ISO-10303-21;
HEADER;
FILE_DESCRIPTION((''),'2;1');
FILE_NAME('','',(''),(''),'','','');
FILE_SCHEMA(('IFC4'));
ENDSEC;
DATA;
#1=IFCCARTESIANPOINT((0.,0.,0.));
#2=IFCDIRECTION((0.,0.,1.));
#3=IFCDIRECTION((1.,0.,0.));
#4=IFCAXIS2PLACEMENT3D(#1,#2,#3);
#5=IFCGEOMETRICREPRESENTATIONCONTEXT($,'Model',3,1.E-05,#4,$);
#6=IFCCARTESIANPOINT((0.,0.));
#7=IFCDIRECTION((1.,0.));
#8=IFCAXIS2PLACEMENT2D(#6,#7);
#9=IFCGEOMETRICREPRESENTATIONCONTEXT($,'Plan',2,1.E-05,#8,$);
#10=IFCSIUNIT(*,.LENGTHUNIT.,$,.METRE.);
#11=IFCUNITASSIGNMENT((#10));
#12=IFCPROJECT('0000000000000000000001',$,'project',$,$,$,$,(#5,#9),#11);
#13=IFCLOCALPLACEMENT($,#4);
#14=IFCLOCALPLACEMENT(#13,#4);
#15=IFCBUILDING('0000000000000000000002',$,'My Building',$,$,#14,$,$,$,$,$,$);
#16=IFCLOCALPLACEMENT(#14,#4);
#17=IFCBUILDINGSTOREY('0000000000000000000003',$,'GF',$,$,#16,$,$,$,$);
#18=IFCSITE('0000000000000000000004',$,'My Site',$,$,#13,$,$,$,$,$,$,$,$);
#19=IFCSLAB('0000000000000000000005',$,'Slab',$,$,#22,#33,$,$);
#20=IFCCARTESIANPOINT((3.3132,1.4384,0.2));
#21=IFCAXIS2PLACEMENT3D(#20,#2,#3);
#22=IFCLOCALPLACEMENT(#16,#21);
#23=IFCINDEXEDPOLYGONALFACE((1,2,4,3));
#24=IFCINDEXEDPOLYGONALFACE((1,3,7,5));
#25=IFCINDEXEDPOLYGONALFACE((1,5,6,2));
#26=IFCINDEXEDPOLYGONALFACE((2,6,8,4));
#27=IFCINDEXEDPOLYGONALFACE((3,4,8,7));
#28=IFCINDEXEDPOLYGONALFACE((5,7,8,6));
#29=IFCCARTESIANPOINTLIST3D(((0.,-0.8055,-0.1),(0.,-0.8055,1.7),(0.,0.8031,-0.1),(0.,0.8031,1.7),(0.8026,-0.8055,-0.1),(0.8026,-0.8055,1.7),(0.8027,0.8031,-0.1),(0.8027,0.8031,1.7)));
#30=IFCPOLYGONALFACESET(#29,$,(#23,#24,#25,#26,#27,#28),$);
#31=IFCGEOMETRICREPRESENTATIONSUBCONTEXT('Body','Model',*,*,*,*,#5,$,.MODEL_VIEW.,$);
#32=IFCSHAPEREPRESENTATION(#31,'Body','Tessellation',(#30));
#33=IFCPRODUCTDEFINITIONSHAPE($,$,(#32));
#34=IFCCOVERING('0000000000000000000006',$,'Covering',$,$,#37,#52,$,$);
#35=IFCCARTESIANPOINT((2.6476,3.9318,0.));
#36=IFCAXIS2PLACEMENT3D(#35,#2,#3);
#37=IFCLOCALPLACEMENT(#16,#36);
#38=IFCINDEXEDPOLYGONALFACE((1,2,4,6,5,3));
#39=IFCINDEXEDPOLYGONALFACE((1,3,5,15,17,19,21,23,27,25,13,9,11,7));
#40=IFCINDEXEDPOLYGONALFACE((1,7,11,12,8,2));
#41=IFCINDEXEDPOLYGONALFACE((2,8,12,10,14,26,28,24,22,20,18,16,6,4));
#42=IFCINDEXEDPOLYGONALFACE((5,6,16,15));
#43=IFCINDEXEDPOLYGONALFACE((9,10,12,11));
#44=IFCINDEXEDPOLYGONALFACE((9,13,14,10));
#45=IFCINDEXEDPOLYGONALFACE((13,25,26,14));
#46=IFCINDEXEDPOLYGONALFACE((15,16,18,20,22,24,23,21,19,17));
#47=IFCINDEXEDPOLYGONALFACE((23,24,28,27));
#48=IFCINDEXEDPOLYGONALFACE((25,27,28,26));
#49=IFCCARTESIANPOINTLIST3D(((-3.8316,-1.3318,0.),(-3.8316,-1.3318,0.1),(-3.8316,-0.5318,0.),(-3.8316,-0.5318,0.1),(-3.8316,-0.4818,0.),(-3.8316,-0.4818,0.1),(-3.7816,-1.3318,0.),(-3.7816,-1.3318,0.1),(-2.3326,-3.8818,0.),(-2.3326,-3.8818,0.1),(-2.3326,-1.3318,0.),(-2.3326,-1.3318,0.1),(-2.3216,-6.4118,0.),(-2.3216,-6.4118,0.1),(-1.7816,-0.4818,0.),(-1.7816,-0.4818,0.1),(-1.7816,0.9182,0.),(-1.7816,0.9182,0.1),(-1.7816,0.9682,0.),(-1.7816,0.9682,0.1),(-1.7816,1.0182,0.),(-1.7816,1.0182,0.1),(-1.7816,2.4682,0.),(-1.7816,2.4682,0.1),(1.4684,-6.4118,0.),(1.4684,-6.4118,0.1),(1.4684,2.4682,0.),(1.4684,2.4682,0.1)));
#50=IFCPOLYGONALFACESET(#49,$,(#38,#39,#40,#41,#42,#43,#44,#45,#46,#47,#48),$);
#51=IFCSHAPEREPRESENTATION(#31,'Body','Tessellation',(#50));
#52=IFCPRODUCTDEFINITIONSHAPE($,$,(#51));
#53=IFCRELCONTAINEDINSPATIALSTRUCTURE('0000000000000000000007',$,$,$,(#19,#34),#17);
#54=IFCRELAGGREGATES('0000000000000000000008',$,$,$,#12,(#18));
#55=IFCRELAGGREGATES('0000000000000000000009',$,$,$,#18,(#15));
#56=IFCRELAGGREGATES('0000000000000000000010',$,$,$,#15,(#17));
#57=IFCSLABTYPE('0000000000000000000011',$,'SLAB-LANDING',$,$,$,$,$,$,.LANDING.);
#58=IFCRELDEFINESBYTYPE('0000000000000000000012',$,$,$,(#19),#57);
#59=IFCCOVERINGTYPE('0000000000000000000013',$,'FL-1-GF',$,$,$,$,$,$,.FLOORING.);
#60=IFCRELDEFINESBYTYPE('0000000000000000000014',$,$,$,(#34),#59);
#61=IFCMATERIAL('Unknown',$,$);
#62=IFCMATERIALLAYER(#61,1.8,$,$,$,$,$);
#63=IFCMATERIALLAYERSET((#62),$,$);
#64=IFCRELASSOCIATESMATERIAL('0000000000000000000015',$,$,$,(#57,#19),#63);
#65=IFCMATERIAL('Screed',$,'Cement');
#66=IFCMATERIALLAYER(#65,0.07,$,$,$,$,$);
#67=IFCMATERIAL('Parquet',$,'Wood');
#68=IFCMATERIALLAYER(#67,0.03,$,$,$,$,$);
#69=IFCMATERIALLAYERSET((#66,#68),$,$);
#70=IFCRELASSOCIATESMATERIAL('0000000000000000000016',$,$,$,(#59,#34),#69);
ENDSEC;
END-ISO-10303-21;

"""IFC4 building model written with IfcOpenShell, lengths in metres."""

from ifc_helpers import new_model, si_unit, frame, origin_with_axes, origin_2d_with_axis, place, context, subcontext, project, spatial, line, indexed_curve, outline, extrude, material, layer, layer_set, layer_usage, type_object, element, save


model = new_model("IFC4")

# Units and contexts
model_context = context("Model", 3, precision=1e-05, world=origin_with_axes())
plan_context = context("Plan", 2, precision=1e-05, world=origin_2d_with_axis())
body_context_1 = subcontext(model_context, "Body", "Model", "MODEL_VIEW")
ifc_project = project(units=[si_unit("LENGTHUNIT", "METRE")], contexts=[model_context, plan_context])

# Site, building, storey
site_placement = place(None, origin_with_axes())
site = spatial("IfcSite", under=ifc_project, at=site_placement, Name="My Site")
building_placement = place(site_placement, origin_with_axes())
building = spatial("IfcBuilding", under=site, at=building_placement, Name="My Building")
storey_placement = place(building_placement, origin_with_axes())
storey = spatial("IfcBuildingStorey", under=building, at=storey_placement, Name="GF")

# Slab
ifc_material_1 = material(Name="Unknown")
ifc_layer_1 = layer(ifc_material_1, 1.8)
ifc_layer_set_1 = layer_set([ifc_layer_1])
ifc_layer_usage_1 = layer_usage(ifc_layer_set_1, "AXIS3", "POSITIVE", -0.1)
slab_type_1 = type_object("IfcSlabType", Name="SLAB-LANDING", PredefinedType="LANDING", material=ifc_layer_set_1)
slab_1_placement = place(storey_placement, frame((3.3132, 1.4384, 0.2), z_axis=(0.0, 0.0, 1.0), x_axis=(1.0, 0.0, 0.0)))
element("IfcSlab", 1, at=slab_1_placement, inside=storey, type_object=slab_type_1, material=ifc_layer_usage_1, Name="Slab", context=body_context_1, shape_type="SweptSolid", body=[
    extrude(outline(indexed_curve([(0.8027, 0.8031), (0.8026, -0.8055), (0.0, -0.8055), (0.0, 0.8031), (0.8027, 0.8031)])), frame((0.0, 0.0, -0.1), z_axis=(0.0, 0.0, 1.0), x_axis=(1.0, 0.0, 0.0)), (0.0, 0.0, 1.0), 1.8),
])

# Covering
ifc_material_2 = material(Name="Screed", Category="Cement")
ifc_layer_2 = layer(ifc_material_2, 0.07)
ifc_material_3 = material(Name="Parquet", Category="Wood")
ifc_layer_3 = layer(ifc_material_3, 0.03)
ifc_layer_set_2 = layer_set([ifc_layer_2, ifc_layer_3])
ifc_layer_usage_2 = layer_usage(ifc_layer_set_2, "AXIS3", "POSITIVE", 0.0)
covering_type = type_object("IfcCoveringType", Name="FL-1-GF", PredefinedType="FLOORING", material=ifc_layer_set_2)
covering_placement = place(storey_placement, frame((2.6476, 3.9318, 0.0), z_axis=(0.0, 0.0, 1.0), x_axis=(1.0, 0.0, 0.0)))
element("IfcCovering", 2, at=covering_placement, inside=storey, type_object=covering_type, material=ifc_layer_usage_2, Name="Covering", context=body_context_1, shape_type="SweptSolid", body=[
    extrude(outline(indexed_curve([(-1.7816, -0.4818), (-1.7816, 0.9182), (-1.7816, 0.9682), (-1.7816, 1.0182), (-1.7816, 2.4682), (1.4684, 2.4682), (1.4684, -6.4118), (-2.3216, -6.4118), (-2.3326, -3.8818), (-2.3326, -1.3318), (-3.7816, -1.3318), (-3.8316, -1.3318), (-3.8316, -0.5318), (-3.8316, -0.4818)], segments=[line(1, 2, 3, 4, 5, 6, 7, 8, 9, 10, 11, 12, 13, 14, 1)])), origin_with_axes(), (0.0, 0.0, 1.0), 0.1),
])

save(model, "model.ifc")
